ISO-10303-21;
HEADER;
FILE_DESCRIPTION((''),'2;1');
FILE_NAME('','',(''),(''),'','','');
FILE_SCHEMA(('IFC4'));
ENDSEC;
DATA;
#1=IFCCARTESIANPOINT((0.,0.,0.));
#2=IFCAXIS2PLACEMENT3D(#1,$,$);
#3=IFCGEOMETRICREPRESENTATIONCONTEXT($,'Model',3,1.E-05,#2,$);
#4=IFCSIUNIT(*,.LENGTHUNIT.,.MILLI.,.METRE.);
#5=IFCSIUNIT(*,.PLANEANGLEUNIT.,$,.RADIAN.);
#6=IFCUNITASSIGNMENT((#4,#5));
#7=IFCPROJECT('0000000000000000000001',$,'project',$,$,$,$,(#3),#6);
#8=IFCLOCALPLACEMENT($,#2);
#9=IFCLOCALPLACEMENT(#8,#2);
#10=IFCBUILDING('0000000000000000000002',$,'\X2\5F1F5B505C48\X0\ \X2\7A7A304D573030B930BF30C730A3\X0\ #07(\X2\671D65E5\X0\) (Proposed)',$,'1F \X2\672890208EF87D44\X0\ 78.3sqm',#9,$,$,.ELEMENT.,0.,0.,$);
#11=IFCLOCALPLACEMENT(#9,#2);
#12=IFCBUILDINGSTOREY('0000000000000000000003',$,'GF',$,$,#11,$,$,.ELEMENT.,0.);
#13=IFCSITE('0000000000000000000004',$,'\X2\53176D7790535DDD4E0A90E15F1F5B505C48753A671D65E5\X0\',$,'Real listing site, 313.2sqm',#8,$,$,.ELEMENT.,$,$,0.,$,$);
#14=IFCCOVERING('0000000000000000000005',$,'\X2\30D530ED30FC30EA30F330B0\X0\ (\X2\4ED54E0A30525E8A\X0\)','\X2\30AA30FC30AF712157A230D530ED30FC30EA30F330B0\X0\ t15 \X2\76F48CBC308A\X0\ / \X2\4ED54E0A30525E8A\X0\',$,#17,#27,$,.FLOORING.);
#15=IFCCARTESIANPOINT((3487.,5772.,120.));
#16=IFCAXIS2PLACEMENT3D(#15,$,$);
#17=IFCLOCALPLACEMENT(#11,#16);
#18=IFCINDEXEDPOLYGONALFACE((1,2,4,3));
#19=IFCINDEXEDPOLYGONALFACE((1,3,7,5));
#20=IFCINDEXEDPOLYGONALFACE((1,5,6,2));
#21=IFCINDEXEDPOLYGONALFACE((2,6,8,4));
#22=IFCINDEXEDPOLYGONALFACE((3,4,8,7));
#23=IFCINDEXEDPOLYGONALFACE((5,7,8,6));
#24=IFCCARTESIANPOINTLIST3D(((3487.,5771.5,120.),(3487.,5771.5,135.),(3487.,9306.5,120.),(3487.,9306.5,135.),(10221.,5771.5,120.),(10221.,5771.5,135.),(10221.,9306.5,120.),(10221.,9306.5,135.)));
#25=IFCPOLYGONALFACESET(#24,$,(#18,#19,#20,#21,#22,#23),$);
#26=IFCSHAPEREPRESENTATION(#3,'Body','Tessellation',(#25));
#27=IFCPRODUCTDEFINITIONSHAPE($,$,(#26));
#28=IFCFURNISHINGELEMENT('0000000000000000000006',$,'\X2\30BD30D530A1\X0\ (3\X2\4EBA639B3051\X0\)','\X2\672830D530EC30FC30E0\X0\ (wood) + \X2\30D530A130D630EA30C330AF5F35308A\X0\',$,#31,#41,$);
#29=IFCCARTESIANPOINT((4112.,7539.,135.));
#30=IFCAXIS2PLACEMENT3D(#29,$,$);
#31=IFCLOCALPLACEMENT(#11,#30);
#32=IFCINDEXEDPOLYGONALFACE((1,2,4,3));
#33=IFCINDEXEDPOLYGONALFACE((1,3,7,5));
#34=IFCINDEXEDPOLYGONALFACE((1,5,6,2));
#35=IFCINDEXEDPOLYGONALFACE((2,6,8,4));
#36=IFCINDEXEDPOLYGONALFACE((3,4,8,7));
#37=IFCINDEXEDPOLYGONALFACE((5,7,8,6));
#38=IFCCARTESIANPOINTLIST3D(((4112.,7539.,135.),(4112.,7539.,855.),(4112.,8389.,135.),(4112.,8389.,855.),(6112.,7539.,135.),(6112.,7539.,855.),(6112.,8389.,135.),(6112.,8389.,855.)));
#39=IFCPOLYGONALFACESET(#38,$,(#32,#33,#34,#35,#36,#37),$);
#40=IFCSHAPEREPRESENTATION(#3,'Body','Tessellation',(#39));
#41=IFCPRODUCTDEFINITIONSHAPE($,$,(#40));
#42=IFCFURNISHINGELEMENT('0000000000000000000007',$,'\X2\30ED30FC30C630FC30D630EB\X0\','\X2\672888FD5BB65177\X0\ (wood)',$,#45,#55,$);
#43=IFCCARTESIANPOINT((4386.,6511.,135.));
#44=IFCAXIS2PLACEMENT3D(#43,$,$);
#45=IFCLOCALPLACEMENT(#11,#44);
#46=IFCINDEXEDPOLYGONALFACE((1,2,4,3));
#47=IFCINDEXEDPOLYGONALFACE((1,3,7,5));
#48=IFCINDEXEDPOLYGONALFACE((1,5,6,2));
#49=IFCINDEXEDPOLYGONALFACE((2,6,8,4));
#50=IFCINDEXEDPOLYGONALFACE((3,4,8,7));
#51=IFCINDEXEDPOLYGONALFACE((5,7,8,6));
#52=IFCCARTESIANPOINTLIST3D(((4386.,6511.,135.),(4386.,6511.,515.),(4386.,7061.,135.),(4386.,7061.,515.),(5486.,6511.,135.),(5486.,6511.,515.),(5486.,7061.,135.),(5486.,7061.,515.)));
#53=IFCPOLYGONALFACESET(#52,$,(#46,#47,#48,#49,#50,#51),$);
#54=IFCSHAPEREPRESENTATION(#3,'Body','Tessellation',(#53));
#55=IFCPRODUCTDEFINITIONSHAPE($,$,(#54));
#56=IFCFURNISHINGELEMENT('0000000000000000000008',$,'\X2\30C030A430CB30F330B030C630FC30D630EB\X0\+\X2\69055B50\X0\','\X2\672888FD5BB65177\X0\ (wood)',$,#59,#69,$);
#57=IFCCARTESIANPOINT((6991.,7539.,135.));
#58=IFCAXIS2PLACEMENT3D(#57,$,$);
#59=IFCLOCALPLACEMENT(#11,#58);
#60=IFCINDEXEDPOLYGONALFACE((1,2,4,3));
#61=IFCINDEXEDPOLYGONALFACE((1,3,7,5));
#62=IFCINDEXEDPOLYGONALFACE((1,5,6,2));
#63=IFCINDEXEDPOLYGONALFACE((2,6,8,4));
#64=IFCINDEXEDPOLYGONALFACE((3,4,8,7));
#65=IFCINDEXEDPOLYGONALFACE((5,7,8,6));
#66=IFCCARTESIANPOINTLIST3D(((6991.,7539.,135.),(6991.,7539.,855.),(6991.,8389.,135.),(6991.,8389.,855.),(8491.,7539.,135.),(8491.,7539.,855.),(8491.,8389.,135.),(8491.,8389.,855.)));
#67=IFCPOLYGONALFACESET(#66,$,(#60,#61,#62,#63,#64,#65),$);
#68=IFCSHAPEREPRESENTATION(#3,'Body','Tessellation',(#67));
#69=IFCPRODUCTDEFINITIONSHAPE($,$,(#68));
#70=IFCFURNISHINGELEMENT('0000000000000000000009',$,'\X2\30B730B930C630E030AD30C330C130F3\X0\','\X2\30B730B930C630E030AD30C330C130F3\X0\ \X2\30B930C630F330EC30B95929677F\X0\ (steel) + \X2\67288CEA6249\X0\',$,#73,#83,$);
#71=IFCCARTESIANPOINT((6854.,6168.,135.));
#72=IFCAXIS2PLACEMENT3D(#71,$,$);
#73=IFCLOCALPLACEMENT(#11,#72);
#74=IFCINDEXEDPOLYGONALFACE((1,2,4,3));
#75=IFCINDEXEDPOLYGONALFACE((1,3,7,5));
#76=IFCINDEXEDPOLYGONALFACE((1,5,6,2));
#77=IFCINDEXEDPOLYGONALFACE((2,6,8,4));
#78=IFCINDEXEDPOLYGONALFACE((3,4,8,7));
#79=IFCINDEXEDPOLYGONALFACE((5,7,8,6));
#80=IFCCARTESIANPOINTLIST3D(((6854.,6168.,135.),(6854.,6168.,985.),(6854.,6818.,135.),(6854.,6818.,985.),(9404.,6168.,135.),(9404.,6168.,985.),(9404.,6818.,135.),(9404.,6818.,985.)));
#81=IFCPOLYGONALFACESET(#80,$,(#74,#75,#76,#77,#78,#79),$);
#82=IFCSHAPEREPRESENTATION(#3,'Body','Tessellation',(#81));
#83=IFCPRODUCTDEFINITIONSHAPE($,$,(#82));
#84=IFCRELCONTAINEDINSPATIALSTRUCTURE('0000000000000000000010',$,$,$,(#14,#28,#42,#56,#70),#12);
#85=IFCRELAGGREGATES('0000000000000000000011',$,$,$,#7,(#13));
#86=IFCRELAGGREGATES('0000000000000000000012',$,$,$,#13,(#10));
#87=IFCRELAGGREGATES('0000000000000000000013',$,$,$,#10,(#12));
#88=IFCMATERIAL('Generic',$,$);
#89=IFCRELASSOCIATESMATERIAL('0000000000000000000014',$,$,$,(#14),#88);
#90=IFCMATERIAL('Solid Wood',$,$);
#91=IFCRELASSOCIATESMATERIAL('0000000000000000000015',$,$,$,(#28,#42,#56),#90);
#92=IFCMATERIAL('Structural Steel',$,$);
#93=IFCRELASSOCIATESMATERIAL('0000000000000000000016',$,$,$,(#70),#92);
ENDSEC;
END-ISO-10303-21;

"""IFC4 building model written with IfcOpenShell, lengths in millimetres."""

from ifc_helpers import new_model, si_unit, frame, frame_2d, origin, place, context, project, spatial, rectangle, extrude, material, element, save


model = new_model("IFC4")

# Units and contexts
model_context = context("Model", 3, precision=1e-05, world=origin())
ifc_project = project(units=[si_unit("LENGTHUNIT", "METRE", prefix="MILLI"), si_unit("PLANEANGLEUNIT", "RADIAN")], contexts=[model_context])

# Site, building, storey
site_placement = place(None, origin())
site = spatial("IfcSite", under=ifc_project, at=site_placement, Name="北海道川上郡弟子屈町朝日", ObjectType="Real listing site, 313.2sqm", CompositionType="ELEMENT", RefElevation=0.0)
building_placement = place(site_placement, origin())
building = spatial("IfcBuilding", under=site, at=building_placement, Name="弟子屈 空き地スタディ #07(朝日) (Proposed)", ObjectType="1F 木造軸組 78.3sqm", CompositionType="ELEMENT", ElevationOfRefHeight=0.0, ElevationOfTerrain=0.0)
storey_placement = place(building_placement, origin())
storey = spatial("IfcBuildingStorey", under=building, at=storey_placement, Name="GF", CompositionType="ELEMENT", Elevation=0.0)

# Shared definitions
ifc_material_1 = material(Name="Solid Wood")

# Shared definitions
ifc_material_2 = material(Name="Structural Steel")

# Covering
ifc_material_3 = material(Name="Generic")
covering_placement = place(storey_placement, frame((3487.0, 5772.0, 120.0)))
element("IfcCovering", 1, at=covering_placement, inside=storey, material=ifc_material_3, Name="フローリング (仕上げ床)", Description="オーク無垢フローリング t15 直貼り / 仕上げ床", PredefinedType="FLOORING", context=model_context, shape_type="SweptSolid", body=[
    extrude(rectangle(XDim=6734.0, YDim=3535.0, at=frame_2d((3367.0, 1767.0))), frame((3487.0, 5772.0, 120.0)), (0.0, 0.0, 1.0), 15.0),
])

# Furnishing elements
furnishing_1_placement = place(storey_placement, frame((4112.0, 7539.0, 135.0)))
element("IfcFurnishingElement", 2, at=furnishing_1_placement, inside=storey, material=ifc_material_1, Name="ソファ (3人掛け)", Description="木フレーム (wood) + ファブリック張り", context=model_context, shape_type="SweptSolid", body=[
    extrude(rectangle(XDim=2000.0, YDim=850.0, at=frame_2d((1000.0, 425.0))), frame((4112.0, 7539.0, 135.0)), (0.0, 0.0, 1.0), 720.0),
])
furnishing_2_placement = place(storey_placement, frame((4386.0, 6511.0, 135.0)))
element("IfcFurnishingElement", 3, at=furnishing_2_placement, inside=storey, material=ifc_material_1, Name="ローテーブル", Description="木製家具 (wood)", context=model_context, shape_type="SweptSolid", body=[
    extrude(rectangle(XDim=1100.0, YDim=550.0, at=frame_2d((550.0, 275.0))), frame((4386.0, 6511.0, 135.0)), (0.0, 0.0, 1.0), 380.0),
])
furnishing_3_placement = place(storey_placement, frame((6991.0, 7539.0, 135.0)))
element("IfcFurnishingElement", 4, at=furnishing_3_placement, inside=storey, material=ifc_material_1, Name="ダイニングテーブル+椅子", Description="木製家具 (wood)", context=model_context, shape_type="SweptSolid", body=[
    extrude(rectangle(XDim=1500.0, YDim=850.0, at=frame_2d((750.0, 425.0))), frame((6991.0, 7539.0, 135.0)), (0.0, 0.0, 1.0), 720.0),
])
furnishing_4_placement = place(storey_placement, frame((6854.0, 6168.0, 135.0)))
element("IfcFurnishingElement", 5, at=furnishing_4_placement, inside=storey, material=ifc_material_2, Name="システムキッチン", Description="システムキッチン ステンレス天板 (steel) + 木質扉", context=model_context, shape_type="SweptSolid", body=[
    extrude(rectangle(XDim=2550.0, YDim=650.0, at=frame_2d((1275.0, 325.0))), frame((6854.0, 6168.0, 135.0)), (0.0, 0.0, 1.0), 850.0),
])

save(model, "model.ifc")
